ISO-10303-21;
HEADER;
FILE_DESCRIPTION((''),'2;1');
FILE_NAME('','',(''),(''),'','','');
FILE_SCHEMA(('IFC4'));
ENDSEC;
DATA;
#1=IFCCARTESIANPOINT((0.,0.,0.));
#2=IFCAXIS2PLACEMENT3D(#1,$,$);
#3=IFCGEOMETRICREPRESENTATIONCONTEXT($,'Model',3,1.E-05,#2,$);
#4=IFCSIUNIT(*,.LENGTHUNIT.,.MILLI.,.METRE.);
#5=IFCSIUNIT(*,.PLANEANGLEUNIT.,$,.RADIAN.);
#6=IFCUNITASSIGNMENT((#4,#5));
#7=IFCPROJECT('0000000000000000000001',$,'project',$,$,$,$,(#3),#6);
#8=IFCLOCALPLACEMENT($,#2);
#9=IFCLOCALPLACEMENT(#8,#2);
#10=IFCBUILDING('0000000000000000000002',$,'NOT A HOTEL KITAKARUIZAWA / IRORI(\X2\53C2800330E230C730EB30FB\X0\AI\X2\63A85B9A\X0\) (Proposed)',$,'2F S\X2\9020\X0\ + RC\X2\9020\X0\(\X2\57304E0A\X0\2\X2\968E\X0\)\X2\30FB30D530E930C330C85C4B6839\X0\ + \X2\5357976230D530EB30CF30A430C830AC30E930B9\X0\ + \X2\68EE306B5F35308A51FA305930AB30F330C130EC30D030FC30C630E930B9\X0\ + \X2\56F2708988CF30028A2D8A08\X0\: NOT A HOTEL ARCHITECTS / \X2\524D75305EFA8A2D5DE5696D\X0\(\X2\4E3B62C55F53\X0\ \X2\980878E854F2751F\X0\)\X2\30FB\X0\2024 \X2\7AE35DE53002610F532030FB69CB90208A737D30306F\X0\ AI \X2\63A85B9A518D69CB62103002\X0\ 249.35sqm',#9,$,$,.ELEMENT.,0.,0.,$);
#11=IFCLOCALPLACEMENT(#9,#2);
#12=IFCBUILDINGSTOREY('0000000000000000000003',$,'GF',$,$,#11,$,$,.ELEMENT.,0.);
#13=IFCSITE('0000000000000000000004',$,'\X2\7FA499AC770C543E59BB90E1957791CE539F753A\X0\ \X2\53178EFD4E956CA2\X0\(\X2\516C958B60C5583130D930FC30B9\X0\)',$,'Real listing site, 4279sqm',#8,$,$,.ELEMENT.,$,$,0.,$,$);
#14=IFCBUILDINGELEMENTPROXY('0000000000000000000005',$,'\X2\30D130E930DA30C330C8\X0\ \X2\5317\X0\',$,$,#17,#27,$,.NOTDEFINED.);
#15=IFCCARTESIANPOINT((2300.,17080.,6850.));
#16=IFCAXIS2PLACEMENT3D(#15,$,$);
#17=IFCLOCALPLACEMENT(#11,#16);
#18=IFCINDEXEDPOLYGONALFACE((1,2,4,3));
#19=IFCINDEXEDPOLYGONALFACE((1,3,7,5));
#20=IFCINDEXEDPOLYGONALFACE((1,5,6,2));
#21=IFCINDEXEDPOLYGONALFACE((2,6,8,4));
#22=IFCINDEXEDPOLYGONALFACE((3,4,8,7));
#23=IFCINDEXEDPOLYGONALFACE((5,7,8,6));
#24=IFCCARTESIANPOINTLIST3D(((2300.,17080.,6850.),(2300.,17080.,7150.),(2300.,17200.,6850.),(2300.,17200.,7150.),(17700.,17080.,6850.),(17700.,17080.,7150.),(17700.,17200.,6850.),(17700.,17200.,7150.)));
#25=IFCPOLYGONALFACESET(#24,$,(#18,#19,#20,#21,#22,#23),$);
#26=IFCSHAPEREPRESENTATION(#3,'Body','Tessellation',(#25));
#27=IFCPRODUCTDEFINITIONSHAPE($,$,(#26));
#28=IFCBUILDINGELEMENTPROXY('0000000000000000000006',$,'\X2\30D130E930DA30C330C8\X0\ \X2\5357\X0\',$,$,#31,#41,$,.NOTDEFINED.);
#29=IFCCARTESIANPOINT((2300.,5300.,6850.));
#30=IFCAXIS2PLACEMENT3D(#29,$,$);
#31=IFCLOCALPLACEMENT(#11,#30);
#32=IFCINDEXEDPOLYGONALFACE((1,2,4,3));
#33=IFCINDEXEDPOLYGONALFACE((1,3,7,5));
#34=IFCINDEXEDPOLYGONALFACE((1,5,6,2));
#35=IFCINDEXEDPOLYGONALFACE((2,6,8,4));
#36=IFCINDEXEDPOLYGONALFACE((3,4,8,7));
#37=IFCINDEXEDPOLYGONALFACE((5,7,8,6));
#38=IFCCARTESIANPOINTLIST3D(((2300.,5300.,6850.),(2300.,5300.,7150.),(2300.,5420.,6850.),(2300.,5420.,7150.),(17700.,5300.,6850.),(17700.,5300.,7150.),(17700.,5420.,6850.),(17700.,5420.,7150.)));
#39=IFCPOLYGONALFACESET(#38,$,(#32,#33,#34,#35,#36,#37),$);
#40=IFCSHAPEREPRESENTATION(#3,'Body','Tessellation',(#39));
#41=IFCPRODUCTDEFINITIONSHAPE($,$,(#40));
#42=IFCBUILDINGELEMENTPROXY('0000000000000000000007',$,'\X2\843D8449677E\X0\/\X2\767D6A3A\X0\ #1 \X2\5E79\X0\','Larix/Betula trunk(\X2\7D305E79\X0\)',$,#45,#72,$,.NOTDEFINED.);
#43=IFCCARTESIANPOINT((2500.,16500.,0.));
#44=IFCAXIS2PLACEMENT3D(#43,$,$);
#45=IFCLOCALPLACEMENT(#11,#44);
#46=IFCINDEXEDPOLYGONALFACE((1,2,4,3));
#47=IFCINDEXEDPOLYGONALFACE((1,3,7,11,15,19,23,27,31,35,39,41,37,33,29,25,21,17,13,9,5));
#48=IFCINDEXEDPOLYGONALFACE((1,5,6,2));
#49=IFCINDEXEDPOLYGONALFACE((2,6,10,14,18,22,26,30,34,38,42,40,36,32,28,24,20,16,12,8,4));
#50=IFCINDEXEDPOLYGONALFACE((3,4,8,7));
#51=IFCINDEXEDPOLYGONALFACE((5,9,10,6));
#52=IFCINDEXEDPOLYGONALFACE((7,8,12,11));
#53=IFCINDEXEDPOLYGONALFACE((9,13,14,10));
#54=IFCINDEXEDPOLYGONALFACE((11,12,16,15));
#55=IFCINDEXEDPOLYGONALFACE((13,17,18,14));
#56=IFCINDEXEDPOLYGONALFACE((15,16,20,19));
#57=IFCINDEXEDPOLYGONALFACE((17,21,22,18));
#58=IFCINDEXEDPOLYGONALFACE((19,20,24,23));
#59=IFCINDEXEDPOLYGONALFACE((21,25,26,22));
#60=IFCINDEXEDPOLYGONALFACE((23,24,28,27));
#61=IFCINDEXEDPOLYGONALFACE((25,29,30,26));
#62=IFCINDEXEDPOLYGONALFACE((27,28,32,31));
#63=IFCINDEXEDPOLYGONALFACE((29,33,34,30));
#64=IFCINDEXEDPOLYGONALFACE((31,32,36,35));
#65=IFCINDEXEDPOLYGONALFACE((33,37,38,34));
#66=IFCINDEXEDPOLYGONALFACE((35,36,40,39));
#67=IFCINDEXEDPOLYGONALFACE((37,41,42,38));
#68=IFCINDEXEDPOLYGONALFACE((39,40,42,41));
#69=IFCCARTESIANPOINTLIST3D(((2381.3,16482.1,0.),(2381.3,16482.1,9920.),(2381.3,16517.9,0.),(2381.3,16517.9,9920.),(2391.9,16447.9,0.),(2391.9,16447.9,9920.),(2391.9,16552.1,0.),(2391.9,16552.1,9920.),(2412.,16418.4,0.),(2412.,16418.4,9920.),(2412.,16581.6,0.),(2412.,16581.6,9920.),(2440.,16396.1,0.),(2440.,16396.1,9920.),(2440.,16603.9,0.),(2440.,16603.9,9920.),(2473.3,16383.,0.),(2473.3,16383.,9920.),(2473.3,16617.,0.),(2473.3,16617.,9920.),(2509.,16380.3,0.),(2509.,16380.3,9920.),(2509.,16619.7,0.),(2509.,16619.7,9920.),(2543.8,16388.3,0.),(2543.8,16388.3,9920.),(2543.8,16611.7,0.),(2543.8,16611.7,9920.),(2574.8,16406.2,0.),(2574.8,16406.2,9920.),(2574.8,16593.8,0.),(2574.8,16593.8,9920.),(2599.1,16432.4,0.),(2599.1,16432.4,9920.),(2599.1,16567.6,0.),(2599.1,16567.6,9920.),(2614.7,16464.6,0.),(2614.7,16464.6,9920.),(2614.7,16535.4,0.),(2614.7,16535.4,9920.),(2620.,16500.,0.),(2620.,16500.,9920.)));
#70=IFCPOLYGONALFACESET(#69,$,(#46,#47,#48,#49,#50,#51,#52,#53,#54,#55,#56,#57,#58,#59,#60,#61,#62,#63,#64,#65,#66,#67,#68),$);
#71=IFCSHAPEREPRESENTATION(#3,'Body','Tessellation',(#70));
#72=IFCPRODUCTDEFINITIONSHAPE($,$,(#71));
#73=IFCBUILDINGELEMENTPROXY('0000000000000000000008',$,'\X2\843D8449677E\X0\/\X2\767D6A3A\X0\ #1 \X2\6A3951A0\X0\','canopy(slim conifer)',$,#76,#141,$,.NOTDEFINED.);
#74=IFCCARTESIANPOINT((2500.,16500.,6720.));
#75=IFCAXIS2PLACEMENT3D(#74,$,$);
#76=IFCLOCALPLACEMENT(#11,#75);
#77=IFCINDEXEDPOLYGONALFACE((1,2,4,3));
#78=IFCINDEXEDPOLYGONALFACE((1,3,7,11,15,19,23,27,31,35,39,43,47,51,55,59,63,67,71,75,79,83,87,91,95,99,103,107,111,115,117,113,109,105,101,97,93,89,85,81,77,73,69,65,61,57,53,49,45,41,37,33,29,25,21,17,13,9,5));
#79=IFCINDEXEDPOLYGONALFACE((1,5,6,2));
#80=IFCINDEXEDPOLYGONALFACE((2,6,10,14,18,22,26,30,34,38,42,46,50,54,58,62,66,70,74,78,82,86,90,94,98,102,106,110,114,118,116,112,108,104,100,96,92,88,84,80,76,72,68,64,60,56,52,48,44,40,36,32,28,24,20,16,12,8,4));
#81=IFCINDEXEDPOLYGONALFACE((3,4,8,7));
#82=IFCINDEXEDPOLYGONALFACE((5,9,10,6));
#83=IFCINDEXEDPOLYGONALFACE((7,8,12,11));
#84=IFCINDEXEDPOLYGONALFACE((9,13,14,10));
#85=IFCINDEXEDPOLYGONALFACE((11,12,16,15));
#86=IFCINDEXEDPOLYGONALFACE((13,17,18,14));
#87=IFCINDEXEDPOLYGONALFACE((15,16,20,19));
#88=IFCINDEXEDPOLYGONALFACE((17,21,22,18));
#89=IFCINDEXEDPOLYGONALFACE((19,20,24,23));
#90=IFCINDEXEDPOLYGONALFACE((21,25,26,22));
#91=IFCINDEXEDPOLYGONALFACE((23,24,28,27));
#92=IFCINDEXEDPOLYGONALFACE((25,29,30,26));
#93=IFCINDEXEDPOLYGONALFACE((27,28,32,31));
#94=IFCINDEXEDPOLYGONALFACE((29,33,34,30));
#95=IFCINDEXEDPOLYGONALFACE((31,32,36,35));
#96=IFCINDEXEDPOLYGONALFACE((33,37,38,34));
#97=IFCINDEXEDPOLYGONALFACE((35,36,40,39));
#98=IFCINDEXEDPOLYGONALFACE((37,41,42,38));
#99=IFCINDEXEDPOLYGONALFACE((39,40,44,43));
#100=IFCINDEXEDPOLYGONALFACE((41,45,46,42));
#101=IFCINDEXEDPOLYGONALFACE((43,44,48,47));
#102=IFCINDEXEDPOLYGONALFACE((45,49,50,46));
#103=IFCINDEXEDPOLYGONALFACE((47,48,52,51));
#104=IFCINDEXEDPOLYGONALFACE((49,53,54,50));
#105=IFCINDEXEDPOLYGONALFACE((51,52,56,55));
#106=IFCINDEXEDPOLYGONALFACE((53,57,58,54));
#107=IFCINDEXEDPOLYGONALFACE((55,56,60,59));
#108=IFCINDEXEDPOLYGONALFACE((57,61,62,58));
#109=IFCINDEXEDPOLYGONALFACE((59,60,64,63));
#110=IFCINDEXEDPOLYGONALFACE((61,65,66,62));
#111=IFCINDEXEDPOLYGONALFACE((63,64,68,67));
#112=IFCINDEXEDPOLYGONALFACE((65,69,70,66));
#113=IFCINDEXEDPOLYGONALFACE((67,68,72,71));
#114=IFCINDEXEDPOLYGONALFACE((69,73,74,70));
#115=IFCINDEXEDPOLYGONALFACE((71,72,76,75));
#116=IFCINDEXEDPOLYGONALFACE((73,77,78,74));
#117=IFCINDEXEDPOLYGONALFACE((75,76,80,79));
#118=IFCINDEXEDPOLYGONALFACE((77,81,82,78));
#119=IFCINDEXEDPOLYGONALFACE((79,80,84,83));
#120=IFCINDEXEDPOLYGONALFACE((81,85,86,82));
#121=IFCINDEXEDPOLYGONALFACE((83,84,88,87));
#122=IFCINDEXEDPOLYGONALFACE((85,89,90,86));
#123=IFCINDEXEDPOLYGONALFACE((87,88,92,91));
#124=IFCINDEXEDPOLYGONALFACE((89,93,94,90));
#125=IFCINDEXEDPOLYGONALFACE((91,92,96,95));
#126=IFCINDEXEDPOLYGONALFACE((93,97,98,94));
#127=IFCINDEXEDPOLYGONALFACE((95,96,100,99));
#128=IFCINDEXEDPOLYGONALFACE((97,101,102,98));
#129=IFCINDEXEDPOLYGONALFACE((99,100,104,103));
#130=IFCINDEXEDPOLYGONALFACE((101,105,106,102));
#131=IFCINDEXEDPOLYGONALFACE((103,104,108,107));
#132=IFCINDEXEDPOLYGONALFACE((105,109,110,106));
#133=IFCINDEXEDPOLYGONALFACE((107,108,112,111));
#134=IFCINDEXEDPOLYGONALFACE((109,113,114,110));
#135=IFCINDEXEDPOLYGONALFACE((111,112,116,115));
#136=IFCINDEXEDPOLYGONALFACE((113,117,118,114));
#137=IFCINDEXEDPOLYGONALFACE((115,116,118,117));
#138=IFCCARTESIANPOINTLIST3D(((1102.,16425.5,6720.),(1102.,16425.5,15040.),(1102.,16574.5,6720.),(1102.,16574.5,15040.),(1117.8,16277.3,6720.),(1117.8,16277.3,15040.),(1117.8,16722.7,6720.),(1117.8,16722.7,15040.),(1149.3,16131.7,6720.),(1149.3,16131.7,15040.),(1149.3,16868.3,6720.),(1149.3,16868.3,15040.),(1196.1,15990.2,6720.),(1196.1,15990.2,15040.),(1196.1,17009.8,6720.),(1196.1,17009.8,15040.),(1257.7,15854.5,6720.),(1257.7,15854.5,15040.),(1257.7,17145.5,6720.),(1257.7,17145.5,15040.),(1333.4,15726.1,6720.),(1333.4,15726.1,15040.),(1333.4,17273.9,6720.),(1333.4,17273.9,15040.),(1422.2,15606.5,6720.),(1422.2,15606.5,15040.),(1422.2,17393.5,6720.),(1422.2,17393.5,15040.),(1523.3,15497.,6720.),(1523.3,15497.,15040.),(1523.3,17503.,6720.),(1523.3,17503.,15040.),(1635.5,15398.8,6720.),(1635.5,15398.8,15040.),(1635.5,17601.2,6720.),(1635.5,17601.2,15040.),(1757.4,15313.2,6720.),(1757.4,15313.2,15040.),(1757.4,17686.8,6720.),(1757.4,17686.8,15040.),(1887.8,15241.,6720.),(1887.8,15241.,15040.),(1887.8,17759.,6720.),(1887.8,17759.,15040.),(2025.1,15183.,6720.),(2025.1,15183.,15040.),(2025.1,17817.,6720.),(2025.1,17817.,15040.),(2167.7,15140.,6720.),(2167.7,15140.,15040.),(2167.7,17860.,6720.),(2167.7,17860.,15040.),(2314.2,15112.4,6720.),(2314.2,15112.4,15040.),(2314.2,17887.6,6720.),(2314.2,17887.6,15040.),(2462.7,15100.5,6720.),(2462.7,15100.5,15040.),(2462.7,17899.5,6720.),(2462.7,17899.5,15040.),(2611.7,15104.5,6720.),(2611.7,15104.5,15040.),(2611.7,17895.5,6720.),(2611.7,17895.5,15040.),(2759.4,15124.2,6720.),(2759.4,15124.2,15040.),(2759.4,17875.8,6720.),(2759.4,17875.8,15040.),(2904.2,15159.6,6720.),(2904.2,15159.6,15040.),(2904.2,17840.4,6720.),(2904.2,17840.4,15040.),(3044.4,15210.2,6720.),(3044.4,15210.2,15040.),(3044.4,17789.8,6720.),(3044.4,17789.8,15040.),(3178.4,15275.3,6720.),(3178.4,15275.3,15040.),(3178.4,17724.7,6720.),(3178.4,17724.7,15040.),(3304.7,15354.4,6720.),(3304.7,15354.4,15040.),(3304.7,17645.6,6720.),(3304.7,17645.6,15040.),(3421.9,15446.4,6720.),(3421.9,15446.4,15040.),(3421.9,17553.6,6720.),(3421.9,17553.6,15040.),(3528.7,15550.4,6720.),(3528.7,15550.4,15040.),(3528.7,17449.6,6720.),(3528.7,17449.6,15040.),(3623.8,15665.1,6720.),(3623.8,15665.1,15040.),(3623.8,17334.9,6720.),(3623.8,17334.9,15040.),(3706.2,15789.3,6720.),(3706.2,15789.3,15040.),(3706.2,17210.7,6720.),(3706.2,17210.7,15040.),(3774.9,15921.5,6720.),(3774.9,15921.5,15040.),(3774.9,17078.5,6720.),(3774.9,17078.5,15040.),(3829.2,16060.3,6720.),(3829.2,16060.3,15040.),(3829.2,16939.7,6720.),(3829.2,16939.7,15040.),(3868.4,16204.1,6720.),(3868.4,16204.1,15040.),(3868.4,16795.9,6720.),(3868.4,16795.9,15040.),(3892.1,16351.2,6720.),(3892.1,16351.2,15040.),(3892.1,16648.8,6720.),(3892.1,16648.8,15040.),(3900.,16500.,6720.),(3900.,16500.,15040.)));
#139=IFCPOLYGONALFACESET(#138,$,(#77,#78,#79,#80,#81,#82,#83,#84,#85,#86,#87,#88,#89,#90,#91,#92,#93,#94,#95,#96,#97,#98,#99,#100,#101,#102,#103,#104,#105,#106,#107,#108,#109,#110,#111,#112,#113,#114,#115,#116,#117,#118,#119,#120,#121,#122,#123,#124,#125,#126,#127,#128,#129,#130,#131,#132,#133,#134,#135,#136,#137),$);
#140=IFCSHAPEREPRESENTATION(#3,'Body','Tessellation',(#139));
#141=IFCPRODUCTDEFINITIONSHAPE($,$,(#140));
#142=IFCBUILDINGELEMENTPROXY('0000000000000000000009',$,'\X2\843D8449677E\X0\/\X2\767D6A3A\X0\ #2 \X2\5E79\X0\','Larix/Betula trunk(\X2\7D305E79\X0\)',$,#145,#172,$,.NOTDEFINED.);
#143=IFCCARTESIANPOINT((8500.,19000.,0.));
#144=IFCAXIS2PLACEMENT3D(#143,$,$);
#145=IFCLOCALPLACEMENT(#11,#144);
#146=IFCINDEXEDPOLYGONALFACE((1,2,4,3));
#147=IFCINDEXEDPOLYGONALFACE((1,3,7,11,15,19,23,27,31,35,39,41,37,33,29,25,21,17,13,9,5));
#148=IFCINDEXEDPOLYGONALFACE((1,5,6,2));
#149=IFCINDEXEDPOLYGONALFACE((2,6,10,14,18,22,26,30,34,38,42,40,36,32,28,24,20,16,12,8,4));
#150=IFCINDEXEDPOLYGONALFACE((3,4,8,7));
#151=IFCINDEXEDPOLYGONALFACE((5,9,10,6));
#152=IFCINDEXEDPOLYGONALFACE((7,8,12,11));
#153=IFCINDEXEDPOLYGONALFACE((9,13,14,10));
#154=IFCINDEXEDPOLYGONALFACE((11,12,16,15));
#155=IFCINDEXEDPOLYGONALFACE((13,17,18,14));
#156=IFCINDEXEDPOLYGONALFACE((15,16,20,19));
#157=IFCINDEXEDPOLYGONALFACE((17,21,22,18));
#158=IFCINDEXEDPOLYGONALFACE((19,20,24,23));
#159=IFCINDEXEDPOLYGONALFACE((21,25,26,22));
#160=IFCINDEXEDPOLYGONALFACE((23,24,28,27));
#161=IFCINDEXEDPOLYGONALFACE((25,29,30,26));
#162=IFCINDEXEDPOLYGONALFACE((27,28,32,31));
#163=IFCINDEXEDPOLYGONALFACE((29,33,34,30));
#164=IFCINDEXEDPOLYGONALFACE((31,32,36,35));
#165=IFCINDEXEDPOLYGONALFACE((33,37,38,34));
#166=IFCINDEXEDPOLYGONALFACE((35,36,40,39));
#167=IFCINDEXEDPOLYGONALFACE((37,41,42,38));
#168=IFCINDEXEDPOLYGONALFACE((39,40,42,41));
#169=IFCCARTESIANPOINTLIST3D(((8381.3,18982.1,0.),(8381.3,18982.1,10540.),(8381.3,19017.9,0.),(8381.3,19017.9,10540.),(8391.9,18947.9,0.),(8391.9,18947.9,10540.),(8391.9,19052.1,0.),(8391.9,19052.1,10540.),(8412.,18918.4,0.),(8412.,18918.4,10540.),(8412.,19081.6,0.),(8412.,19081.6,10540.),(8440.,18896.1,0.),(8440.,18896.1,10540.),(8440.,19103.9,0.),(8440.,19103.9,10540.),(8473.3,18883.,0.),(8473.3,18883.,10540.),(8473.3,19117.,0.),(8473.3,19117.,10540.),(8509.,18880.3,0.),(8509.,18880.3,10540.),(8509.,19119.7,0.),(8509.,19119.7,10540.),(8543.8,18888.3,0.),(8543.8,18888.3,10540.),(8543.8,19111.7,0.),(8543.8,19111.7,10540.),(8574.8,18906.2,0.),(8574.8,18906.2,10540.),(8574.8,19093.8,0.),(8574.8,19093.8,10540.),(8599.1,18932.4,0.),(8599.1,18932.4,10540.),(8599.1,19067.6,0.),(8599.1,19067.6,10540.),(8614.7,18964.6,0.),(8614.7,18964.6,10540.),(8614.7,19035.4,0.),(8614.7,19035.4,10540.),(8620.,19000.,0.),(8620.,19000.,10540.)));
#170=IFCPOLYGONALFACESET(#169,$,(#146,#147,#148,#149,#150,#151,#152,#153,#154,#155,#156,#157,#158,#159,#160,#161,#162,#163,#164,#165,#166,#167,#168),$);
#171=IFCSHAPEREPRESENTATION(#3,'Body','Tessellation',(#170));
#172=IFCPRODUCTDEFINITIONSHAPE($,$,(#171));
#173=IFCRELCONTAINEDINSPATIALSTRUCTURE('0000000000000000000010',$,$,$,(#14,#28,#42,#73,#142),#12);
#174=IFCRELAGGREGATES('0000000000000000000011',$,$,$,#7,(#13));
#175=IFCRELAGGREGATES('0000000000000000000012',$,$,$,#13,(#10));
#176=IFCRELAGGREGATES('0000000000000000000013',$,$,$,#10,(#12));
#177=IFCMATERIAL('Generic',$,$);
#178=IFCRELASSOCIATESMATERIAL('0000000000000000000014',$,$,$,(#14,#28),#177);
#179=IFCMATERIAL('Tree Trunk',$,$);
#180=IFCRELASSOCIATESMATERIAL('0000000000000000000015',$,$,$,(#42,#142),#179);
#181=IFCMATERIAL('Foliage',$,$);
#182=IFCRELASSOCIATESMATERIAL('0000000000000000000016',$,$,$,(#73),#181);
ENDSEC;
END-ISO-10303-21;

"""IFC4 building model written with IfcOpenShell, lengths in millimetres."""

from ifc_helpers import new_model, si_unit, frame, frame_2d, origin, origin_2d, place, context, project, spatial, rectangle, circle, extrude, material, element, save


model = new_model("IFC4")

# Units and contexts
model_context = context("Model", 3, precision=1e-05, world=origin())
ifc_project = project(units=[si_unit("LENGTHUNIT", "METRE", prefix="MILLI"), si_unit("PLANEANGLEUNIT", "RADIAN")], contexts=[model_context])

# Site, building, storey
site_placement = place(None, origin())
site = spatial("IfcSite", under=ifc_project, at=site_placement, Name="群馬県吾妻郡長野原町 北軽井沢(公開情報ベース)", ObjectType="Real listing site, 4279sqm", CompositionType="ELEMENT", RefElevation=0.0)
building_placement = place(site_placement, origin())
building = spatial("IfcBuilding", under=site, at=building_placement, Name="NOT A HOTEL KITAKARUIZAWA / IRORI(参考モデル・AI推定) (Proposed)", ObjectType="2F S造 + RC造(地上2階)・フラット屋根 + 南面フルハイトガラス + 森に張り出すカンチレバーテラス + 囲炉裏。設計: NOT A HOTEL ARCHITECTS / 前田建設工業(主担当 須磨哲生)・2024 竣工。意匠・構造詳細は AI 推定再構成。 249.35sqm", CompositionType="ELEMENT", ElevationOfRefHeight=0.0, ElevationOfTerrain=0.0)
storey_placement = place(building_placement, origin())
storey = spatial("IfcBuildingStorey", under=building, at=storey_placement, Name="GF", CompositionType="ELEMENT", Elevation=0.0)

# Shared definitions
ifc_material_1 = material(Name="Generic")

# Shared definitions
ifc_material_2 = material(Name="Foliage")

# Building element proxies
proxy_1_placement = place(storey_placement, frame((2300.0, 17080.0, 6850.0)))
element("IfcBuildingElementProxy", 1, at=proxy_1_placement, inside=storey, material=ifc_material_1, Name="パラペット 北", PredefinedType="NOTDEFINED", context=model_context, shape_type="SweptSolid", body=[
    extrude(rectangle(XDim=15400.0, YDim=120.0, at=frame_2d((7700.0, 60.0))), frame((2300.0, 17080.0, 6850.0)), (0.0, 0.0, 1.0), 300.0),
])
proxy_2_placement = place(storey_placement, frame((2300.0, 5300.0, 6850.0)))
element("IfcBuildingElementProxy", 2, at=proxy_2_placement, inside=storey, material=ifc_material_1, Name="パラペット 南", PredefinedType="NOTDEFINED", context=model_context, shape_type="SweptSolid", body=[
    extrude(rectangle(XDim=15400.0, YDim=120.0, at=frame_2d((7700.0, 60.0))), frame((2300.0, 5300.0, 6850.0)), (0.0, 0.0, 1.0), 300.0),
])
ifc_material_3 = material(Name="Tree Trunk")
proxy_3_placement = place(storey_placement, frame((2500.0, 16500.0, 0.0)))
element("IfcBuildingElementProxy", 3, at=proxy_3_placement, inside=storey, material=ifc_material_3, Name="落葉松/白樺 #1 幹", Description="Larix/Betula trunk(細幹)", PredefinedType="NOTDEFINED", context=model_context, shape_type="SweptSolid", body=[
    extrude(circle(Radius=120.0, at=origin_2d()), frame((2500.0, 16500.0, 0.0)), (0.0, 0.0, 1.0), 9920.0),
])
proxy_4_placement = place(storey_placement, frame((2500.0, 16500.0, 6720.0)))
element("IfcBuildingElementProxy", 4, at=proxy_4_placement, inside=storey, material=ifc_material_2, Name="落葉松/白樺 #1 樹冠", Description="canopy(slim conifer)", PredefinedType="NOTDEFINED", context=model_context, shape_type="SweptSolid", body=[
    extrude(circle(Radius=1400.0, at=origin_2d()), frame((2500.0, 16500.0, 6720.0)), (0.0, 0.0, 1.0), 8320.0),
])
proxy_5_placement = place(storey_placement, frame((8500.0, 19000.0, 0.0)))
element("IfcBuildingElementProxy", 5, at=proxy_5_placement, inside=storey, material=ifc_material_3, Name="落葉松/白樺 #2 幹", Description="Larix/Betula trunk(細幹)", PredefinedType="NOTDEFINED", context=model_context, shape_type="SweptSolid", body=[
    extrude(circle(Radius=120.0, at=origin_2d()), frame((8500.0, 19000.0, 0.0)), (0.0, 0.0, 1.0), 10540.0),
])

save(model, "model.ifc")
